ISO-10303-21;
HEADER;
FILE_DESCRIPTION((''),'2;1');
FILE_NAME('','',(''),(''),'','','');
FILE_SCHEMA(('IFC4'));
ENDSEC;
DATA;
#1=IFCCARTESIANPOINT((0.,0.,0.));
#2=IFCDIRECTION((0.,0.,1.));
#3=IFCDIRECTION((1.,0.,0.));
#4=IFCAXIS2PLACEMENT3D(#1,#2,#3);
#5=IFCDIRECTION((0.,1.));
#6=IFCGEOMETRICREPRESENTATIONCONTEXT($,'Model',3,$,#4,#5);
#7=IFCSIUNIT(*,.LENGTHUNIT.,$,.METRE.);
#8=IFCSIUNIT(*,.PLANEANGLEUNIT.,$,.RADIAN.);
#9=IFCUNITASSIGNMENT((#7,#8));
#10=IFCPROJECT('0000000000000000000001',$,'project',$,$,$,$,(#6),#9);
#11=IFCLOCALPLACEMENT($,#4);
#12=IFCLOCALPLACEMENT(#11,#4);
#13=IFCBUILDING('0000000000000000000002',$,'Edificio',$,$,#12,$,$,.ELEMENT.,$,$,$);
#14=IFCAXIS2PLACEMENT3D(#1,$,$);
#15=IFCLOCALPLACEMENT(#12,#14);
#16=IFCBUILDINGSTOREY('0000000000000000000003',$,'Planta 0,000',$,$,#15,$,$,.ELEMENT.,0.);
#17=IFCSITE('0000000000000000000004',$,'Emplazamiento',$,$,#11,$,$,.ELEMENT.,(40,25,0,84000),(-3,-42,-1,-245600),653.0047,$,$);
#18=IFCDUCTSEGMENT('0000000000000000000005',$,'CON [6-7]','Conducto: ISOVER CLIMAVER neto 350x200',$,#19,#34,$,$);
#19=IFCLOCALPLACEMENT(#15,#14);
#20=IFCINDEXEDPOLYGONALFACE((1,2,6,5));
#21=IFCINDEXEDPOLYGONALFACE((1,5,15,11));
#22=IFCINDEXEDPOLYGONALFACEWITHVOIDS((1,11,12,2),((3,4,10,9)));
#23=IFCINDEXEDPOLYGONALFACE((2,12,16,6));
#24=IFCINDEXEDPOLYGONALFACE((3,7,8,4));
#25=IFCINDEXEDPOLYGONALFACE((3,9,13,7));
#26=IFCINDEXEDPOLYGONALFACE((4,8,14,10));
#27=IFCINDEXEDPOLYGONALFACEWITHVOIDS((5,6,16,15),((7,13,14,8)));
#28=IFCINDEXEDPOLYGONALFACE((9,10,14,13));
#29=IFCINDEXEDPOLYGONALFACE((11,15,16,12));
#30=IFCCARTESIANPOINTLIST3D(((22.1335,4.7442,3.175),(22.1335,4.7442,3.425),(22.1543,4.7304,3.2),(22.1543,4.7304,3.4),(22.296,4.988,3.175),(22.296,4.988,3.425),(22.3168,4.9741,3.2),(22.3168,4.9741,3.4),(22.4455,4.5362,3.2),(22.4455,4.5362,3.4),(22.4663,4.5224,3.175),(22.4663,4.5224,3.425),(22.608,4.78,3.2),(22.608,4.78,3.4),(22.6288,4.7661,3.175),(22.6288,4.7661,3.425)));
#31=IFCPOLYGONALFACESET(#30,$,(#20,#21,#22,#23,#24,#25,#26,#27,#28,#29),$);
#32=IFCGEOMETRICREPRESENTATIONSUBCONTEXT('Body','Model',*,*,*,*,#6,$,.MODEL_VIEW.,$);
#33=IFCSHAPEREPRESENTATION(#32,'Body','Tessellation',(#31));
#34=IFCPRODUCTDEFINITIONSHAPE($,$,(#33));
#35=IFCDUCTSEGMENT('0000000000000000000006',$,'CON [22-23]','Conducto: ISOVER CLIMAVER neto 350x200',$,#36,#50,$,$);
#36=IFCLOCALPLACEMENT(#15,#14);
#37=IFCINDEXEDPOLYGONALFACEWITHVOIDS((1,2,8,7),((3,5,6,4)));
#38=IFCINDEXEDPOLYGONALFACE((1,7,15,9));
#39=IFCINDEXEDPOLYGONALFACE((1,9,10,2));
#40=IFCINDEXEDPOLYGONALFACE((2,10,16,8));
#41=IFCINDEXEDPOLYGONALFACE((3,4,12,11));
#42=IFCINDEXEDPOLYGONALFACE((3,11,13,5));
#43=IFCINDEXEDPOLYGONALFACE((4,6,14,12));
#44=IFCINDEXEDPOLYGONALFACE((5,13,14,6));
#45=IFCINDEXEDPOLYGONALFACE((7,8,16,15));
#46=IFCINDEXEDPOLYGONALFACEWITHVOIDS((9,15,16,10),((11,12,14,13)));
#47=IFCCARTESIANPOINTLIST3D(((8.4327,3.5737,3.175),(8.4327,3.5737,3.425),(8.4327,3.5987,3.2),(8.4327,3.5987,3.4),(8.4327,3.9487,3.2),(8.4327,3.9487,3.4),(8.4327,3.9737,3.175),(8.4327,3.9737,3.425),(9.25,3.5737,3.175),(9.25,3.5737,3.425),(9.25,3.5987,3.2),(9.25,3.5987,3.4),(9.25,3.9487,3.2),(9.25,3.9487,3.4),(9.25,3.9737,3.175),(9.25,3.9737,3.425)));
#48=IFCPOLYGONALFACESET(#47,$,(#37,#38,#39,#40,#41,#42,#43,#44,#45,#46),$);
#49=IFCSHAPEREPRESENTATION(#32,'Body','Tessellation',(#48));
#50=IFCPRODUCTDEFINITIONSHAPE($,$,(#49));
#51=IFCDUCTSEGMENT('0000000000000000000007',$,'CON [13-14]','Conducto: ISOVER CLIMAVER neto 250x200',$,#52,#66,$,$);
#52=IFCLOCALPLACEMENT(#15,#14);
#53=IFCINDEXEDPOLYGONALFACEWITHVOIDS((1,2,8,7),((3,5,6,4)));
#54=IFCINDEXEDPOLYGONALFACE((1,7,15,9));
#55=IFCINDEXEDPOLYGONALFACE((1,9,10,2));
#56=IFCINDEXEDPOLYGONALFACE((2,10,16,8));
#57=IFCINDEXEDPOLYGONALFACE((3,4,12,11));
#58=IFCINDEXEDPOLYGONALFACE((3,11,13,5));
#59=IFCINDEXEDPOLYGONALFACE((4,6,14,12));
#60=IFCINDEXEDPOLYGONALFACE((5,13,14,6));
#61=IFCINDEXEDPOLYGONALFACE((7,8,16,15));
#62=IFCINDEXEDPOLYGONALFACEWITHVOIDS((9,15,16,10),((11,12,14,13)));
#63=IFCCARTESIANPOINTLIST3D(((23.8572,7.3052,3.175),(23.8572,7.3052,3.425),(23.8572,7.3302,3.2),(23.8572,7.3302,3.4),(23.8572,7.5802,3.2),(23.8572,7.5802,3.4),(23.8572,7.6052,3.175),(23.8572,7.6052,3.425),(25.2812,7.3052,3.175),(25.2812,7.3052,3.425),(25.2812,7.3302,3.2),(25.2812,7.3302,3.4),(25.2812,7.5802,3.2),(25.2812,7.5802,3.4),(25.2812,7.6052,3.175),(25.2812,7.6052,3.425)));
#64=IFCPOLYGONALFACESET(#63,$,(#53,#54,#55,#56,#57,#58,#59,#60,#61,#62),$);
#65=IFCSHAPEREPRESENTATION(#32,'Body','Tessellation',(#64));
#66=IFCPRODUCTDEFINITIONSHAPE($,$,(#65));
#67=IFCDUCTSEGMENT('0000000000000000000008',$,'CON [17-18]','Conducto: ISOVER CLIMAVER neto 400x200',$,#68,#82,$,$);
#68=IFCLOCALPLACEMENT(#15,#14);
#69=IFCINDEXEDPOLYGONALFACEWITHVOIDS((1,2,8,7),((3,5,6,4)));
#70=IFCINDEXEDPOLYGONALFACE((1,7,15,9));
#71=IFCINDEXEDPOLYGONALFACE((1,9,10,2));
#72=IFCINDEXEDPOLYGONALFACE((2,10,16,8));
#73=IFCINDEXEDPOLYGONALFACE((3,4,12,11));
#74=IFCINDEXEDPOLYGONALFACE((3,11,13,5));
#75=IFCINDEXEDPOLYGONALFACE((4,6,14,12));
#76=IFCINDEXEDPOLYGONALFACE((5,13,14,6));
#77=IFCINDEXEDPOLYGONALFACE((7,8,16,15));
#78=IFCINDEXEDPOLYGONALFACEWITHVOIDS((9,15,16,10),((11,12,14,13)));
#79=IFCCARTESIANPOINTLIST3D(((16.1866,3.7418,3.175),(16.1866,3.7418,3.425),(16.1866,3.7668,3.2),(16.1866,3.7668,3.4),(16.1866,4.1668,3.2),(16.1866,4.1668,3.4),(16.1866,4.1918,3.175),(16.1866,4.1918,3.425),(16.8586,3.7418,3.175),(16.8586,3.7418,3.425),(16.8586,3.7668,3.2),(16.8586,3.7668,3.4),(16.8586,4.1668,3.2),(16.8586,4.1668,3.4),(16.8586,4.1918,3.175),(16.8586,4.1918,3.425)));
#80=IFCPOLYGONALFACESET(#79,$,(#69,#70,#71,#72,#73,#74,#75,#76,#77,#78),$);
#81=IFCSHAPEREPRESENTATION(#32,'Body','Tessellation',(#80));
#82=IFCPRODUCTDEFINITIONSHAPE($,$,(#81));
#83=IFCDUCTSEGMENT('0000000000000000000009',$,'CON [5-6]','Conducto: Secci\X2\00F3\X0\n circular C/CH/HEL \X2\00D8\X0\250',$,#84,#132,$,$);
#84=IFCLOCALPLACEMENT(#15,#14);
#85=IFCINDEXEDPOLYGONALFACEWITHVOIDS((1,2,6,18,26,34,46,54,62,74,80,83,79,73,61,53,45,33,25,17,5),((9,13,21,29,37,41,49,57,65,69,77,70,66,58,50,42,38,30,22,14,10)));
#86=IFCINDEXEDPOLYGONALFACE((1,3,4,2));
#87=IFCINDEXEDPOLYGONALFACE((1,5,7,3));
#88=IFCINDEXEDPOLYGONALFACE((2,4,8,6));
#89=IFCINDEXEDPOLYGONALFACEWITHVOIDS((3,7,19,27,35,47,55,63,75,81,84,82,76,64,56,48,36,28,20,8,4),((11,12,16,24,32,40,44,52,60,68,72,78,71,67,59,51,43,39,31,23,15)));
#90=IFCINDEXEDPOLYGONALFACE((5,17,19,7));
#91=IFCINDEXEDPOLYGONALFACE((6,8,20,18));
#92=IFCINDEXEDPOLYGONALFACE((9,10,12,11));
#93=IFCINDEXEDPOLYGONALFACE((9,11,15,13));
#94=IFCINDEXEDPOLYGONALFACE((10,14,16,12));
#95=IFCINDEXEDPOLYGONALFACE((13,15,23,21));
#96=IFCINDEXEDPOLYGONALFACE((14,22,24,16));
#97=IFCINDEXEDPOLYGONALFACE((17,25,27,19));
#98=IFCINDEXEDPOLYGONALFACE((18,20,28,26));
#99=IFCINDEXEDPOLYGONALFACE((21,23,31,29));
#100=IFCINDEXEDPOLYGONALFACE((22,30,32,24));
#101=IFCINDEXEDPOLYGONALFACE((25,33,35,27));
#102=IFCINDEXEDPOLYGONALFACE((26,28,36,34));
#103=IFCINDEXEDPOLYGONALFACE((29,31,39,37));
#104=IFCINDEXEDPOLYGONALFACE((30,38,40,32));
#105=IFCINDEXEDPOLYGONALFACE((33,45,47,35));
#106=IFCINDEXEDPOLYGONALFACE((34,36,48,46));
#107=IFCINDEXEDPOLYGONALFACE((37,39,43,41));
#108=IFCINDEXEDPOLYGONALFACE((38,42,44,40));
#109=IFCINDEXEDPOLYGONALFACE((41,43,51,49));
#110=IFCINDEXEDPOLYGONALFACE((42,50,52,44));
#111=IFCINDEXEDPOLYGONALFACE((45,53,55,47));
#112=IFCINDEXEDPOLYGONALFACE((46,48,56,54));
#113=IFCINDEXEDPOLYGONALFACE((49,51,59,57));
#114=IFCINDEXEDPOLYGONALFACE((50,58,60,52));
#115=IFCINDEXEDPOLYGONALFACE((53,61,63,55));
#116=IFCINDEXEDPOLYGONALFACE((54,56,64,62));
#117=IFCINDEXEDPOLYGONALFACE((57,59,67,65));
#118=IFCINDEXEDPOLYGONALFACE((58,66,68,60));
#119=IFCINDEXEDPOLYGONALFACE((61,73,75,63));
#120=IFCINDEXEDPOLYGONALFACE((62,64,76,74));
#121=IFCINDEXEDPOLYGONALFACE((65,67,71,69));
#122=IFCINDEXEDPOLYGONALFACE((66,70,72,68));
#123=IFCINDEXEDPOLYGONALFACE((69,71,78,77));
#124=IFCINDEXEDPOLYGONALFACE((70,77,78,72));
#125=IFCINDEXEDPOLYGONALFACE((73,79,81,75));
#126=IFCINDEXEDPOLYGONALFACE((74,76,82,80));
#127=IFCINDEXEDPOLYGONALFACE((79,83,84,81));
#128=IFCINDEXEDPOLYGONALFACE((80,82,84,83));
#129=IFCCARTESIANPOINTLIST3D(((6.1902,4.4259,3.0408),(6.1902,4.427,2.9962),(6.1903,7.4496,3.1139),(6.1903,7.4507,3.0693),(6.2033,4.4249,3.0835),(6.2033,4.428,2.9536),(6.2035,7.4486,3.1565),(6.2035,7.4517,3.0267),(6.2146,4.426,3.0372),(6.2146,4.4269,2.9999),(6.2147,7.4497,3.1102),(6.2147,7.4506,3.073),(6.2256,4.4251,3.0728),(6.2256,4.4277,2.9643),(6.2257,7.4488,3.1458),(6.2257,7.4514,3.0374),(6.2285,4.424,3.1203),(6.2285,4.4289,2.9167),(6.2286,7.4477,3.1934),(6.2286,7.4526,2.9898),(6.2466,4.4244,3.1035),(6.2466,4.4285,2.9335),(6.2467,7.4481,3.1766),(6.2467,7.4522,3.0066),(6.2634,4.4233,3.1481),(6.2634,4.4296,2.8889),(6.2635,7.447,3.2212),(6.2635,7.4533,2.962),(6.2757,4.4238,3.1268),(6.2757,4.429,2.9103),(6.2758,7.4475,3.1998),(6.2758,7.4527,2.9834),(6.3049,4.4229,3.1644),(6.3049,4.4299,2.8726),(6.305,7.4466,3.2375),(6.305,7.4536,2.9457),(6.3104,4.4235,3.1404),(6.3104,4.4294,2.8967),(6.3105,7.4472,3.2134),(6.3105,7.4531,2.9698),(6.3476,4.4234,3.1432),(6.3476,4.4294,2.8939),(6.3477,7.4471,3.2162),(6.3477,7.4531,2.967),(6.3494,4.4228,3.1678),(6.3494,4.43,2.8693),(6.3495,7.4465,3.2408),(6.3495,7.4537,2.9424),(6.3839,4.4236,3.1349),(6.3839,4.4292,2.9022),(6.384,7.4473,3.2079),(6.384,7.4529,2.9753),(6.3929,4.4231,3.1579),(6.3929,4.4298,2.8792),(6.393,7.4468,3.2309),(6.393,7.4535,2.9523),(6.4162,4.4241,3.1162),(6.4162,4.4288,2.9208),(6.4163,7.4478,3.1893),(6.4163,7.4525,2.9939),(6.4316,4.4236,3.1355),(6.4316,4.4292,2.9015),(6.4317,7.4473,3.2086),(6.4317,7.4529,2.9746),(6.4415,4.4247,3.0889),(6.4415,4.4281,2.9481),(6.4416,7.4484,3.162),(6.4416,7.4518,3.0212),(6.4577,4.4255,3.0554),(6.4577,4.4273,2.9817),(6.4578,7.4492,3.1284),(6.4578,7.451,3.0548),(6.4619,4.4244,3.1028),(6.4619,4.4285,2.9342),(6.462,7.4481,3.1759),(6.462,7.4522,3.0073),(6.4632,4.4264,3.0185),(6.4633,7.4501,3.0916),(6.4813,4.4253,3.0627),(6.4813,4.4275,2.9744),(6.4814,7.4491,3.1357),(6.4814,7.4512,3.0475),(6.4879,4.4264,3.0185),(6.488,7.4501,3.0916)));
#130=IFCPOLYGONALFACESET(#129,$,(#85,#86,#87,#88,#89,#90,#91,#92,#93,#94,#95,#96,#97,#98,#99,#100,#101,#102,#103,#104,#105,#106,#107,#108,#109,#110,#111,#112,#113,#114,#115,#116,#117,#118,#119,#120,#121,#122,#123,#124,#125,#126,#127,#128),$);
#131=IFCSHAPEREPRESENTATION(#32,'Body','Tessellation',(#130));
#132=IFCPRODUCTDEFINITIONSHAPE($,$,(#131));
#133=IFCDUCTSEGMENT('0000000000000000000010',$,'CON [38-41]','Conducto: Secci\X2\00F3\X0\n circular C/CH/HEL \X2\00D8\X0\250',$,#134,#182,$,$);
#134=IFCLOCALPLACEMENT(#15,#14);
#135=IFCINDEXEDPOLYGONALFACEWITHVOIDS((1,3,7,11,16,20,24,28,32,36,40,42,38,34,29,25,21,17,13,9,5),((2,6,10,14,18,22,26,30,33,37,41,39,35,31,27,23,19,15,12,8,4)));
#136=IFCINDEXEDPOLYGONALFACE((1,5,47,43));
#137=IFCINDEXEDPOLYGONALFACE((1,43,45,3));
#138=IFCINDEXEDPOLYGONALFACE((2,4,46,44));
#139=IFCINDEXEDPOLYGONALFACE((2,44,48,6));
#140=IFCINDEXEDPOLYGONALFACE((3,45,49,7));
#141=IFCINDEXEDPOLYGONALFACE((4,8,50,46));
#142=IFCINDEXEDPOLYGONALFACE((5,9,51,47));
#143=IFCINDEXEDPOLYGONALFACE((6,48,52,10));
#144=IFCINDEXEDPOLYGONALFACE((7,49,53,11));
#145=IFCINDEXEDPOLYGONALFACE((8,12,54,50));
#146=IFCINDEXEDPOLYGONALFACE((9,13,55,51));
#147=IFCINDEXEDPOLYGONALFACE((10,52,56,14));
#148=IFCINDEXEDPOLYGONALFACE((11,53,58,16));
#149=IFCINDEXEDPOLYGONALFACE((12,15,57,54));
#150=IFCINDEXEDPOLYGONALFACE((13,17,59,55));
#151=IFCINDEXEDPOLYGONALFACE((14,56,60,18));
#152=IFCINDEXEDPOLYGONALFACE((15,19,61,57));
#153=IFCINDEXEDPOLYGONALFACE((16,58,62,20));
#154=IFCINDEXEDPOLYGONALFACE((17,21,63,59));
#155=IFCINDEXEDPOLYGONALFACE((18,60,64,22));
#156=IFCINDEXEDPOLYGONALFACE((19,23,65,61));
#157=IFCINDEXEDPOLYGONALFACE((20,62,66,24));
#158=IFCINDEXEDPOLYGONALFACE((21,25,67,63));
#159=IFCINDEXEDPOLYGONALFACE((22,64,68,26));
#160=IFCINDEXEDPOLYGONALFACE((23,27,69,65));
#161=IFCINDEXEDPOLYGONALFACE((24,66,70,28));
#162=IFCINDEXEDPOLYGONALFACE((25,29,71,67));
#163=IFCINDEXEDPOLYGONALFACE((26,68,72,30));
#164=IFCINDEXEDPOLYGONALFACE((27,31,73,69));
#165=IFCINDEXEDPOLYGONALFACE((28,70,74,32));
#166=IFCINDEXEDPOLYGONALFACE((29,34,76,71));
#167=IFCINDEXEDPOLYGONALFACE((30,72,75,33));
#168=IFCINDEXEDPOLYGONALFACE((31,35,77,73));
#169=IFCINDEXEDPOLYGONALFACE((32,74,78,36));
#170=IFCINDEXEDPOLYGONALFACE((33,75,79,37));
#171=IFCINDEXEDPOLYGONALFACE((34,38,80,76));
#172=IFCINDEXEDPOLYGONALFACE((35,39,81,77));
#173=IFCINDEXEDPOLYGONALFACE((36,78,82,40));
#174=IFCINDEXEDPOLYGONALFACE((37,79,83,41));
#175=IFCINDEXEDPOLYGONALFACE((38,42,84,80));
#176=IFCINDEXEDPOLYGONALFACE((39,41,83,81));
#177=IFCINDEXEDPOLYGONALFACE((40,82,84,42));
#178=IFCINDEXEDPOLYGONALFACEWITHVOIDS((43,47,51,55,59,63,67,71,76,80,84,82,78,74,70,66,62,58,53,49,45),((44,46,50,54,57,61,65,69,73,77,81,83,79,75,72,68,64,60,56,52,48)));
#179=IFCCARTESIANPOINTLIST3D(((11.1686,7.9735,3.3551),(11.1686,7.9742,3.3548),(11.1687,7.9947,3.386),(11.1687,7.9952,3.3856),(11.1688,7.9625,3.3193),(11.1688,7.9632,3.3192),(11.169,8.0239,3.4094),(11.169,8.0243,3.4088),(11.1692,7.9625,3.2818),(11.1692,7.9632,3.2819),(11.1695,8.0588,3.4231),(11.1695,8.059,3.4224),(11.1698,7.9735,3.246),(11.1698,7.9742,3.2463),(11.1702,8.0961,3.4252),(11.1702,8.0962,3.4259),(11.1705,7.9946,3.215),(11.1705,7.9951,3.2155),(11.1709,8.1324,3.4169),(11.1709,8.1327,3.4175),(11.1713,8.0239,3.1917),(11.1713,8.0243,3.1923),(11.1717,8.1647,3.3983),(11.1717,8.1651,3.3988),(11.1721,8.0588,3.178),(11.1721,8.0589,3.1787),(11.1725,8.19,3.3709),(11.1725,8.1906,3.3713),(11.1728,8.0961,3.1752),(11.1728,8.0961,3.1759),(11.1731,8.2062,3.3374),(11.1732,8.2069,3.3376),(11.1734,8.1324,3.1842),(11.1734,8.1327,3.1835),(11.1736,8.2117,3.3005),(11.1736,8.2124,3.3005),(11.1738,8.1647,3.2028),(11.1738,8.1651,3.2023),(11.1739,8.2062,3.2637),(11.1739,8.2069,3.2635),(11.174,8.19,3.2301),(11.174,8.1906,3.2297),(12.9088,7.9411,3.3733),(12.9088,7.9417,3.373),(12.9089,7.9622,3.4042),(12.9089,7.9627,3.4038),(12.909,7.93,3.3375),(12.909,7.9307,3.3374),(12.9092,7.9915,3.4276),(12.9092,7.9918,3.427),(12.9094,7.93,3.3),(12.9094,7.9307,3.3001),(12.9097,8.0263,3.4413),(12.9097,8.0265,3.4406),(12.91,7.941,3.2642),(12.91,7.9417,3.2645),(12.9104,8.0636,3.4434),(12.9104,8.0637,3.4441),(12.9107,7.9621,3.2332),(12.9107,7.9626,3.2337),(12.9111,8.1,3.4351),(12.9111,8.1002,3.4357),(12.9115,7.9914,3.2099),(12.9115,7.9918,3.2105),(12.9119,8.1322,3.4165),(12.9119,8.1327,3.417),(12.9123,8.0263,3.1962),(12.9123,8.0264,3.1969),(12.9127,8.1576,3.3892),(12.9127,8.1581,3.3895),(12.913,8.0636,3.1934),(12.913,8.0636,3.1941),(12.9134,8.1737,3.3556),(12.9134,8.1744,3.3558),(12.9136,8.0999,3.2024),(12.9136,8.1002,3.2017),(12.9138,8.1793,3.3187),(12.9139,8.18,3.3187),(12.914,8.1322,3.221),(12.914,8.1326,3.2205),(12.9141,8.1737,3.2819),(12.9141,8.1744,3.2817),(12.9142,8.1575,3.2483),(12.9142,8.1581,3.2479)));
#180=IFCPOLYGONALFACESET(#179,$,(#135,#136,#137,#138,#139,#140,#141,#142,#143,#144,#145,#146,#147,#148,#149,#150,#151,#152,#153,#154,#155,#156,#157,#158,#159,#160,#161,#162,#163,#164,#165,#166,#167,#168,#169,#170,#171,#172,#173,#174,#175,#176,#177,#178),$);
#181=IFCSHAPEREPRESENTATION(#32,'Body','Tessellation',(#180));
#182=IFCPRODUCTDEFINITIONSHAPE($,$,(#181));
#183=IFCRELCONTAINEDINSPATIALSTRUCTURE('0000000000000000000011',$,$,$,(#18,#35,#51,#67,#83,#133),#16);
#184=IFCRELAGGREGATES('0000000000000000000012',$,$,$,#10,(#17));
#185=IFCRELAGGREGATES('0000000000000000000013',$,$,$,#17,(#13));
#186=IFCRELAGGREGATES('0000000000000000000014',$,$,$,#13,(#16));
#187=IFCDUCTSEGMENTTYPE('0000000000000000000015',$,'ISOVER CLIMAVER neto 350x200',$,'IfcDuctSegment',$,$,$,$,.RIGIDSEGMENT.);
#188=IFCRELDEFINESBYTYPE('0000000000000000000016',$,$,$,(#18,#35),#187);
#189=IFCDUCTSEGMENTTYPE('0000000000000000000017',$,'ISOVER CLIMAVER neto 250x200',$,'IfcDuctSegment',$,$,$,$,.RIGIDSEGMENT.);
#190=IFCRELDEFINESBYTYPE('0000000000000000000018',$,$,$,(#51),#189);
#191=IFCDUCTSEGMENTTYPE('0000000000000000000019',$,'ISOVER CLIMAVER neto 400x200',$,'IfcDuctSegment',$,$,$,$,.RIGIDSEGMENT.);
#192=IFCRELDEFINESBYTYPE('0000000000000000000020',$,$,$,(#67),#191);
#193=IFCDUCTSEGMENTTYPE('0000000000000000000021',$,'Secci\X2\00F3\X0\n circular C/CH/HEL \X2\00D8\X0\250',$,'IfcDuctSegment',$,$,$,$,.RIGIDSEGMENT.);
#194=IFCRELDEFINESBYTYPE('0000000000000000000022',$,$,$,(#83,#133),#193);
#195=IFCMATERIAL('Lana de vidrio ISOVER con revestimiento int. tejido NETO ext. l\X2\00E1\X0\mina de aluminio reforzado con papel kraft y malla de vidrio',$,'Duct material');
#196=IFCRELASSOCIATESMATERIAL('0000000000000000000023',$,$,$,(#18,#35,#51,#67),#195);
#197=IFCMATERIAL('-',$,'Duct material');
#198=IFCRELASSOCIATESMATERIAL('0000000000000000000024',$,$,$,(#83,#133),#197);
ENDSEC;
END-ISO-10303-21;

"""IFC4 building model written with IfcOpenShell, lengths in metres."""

from ifc_helpers import new_model, si_unit, direction, frame, origin, origin_with_axes, origin_2d_with_axis, place, context, subcontext, project, spatial, hollow_rectangle, hollow_circle, extrude, material, type_object, element, save


model = new_model("IFC4")

# Units and contexts
model_context = context("Model", 3, world=origin_with_axes(), true_north=direction((0.0, 1.0)))
body_context = subcontext(model_context, "Body", "Model", "MODEL_VIEW")
ifc_project = project(units=[si_unit("LENGTHUNIT", "METRE"), si_unit("PLANEANGLEUNIT", "RADIAN")], contexts=[model_context])

# Site, building, storey
site_placement = place(None, origin_with_axes())
site = spatial("IfcSite", under=ifc_project, at=site_placement, Name="Emplazamiento", CompositionType="ELEMENT", RefLatitude=(40, 25, 0, 84000), RefLongitude=(-3, -42, -1, -245600), RefElevation=653.0047)
building_placement = place(site_placement, origin_with_axes())
building = spatial("IfcBuilding", under=site, at=building_placement, Name="Edificio", CompositionType="ELEMENT")
storey_placement = place(building_placement, origin())
storey = spatial("IfcBuildingStorey", under=building, at=storey_placement, Name="Planta 0,000", CompositionType="ELEMENT", Elevation=0.0)

# Shared definitions
ifc_material_1 = material(Name="Lana de vidrio ISOVER con revestimiento int. tejido NETO ext. lámina de aluminio reforzado con papel kraft y malla de vidrio", Category="Duct material")
ifc_material_2 = material(Name="-", Category="Duct material")

# Duct segments
duct_segment_type_1 = type_object("IfcDuctSegmentType", Name="ISOVER CLIMAVER neto 350x200", ApplicableOccurrence="IfcDuctSegment", PredefinedType="RIGIDSEGMENT")
duct_segment_1_placement = place(storey_placement, origin_with_axes())
element("IfcDuctSegment", 1, at=duct_segment_1_placement, inside=storey, type_object=duct_segment_type_1, material=ifc_material_1, Name="CON [6-7]", Description="Conducto: ISOVER CLIMAVER neto 350x200", context=body_context, shape_type="SweptSolid", body=[
    extrude(hollow_rectangle(XDim=0.4, YDim=0.25, WallThickness=0.025, at=origin_2d_with_axis()), frame((22.2999, 4.6333, 3.3), z_axis=(0.5547, 0.83205, 0.0), x_axis=(-0.83205, 0.5547, 0.0)), (0.0, 0.0, 1.0), 0.293),
])
duct_segment_2_placement = place(storey_placement, origin_with_axes())
element("IfcDuctSegment", 2, at=duct_segment_2_placement, inside=storey, type_object=duct_segment_type_1, material=ifc_material_1, Name="CON [22-23]", Description="Conducto: ISOVER CLIMAVER neto 350x200", context=body_context, shape_type="SweptSolid", body=[
    extrude(hollow_rectangle(XDim=0.4, YDim=0.25, WallThickness=0.025, at=origin_2d_with_axis()), frame((9.25, 3.7737, 3.3), z_axis=(-1.0, 0.0, 0.0), x_axis=(0.0, -1.0, 0.0)), (0.0, 0.0, 1.0), 0.8173),
])
duct_segment_type_2 = type_object("IfcDuctSegmentType", Name="ISOVER CLIMAVER neto 250x200", ApplicableOccurrence="IfcDuctSegment", PredefinedType="RIGIDSEGMENT")
duct_segment_3_placement = place(storey_placement, origin_with_axes())
element("IfcDuctSegment", 3, at=duct_segment_3_placement, inside=storey, type_object=duct_segment_type_2, material=ifc_material_1, Name="CON [13-14]", Description="Conducto: ISOVER CLIMAVER neto 250x200", context=body_context, shape_type="SweptSolid", body=[
    extrude(hollow_rectangle(XDim=0.3, YDim=0.25, WallThickness=0.025, at=origin_2d_with_axis()), frame((25.2812, 7.4552, 3.3), z_axis=(-1.0, 0.0, 0.0), x_axis=(0.0, -1.0, 0.0)), (0.0, 0.0, 1.0), 1.424),
])
duct_segment_type_3 = type_object("IfcDuctSegmentType", Name="ISOVER CLIMAVER neto 400x200", ApplicableOccurrence="IfcDuctSegment", PredefinedType="RIGIDSEGMENT")
duct_segment_4_placement = place(storey_placement, origin_with_axes())
element("IfcDuctSegment", 4, at=duct_segment_4_placement, inside=storey, type_object=duct_segment_type_3, material=ifc_material_1, Name="CON [17-18]", Description="Conducto: ISOVER CLIMAVER neto 400x200", context=body_context, shape_type="SweptSolid", body=[
    extrude(hollow_rectangle(XDim=0.45, YDim=0.25, WallThickness=0.025, at=origin_2d_with_axis()), frame((16.8586, 3.9668, 3.3), z_axis=(-1.0, 0.0, 0.0), x_axis=(0.0, -1.0, 0.0)), (0.0, 0.0, 1.0), 0.672),
])
duct_segment_type_4 = type_object("IfcDuctSegmentType", Name="Sección circular C/CH/HEL Ø250", ApplicableOccurrence="IfcDuctSegment", PredefinedType="RIGIDSEGMENT")
duct_segment_5_placement = place(storey_placement, origin_with_axes())
element("IfcDuctSegment", 5, at=duct_segment_5_placement, inside=storey, type_object=duct_segment_type_4, material=ifc_material_2, Name="CON [5-6]", Description="Conducto: Sección circular C/CH/HEL Ø250", context=body_context, shape_type="SweptSolid", body=[
    extrude(hollow_circle(Radius=0.1497, WallThickness=0.0247, at=origin_2d_with_axis()), frame((6.3383, 7.4501, 3.0916), z_axis=(-0.000036, -0.999708, -0.024154), x_axis=(1.0, -0.000036, 0.0)), (0.0, 0.0, 1.0), 3.0246),
])
duct_segment_6_placement = place(storey_placement, origin_with_axes())
element("IfcDuctSegment", 6, at=duct_segment_6_placement, inside=storey, type_object=duct_segment_type_4, material=ifc_material_2, Name="CON [38-41]", Description="Conducto: Sección circular C/CH/HEL Ø250", context=body_context, shape_type="SweptSolid", body=[
    extrude(hollow_circle(Radius=0.1257, WallThickness=0.0007, at=origin_2d_with_axis()), frame((11.1713, 8.0868, 3.3005), z_axis=(0.999771, -0.018666, 0.010456), x_axis=(0.018667, 0.999826, 0.0)), (0.0, 0.0, 1.0), 1.7406),
])

save(model, "model.ifc")
